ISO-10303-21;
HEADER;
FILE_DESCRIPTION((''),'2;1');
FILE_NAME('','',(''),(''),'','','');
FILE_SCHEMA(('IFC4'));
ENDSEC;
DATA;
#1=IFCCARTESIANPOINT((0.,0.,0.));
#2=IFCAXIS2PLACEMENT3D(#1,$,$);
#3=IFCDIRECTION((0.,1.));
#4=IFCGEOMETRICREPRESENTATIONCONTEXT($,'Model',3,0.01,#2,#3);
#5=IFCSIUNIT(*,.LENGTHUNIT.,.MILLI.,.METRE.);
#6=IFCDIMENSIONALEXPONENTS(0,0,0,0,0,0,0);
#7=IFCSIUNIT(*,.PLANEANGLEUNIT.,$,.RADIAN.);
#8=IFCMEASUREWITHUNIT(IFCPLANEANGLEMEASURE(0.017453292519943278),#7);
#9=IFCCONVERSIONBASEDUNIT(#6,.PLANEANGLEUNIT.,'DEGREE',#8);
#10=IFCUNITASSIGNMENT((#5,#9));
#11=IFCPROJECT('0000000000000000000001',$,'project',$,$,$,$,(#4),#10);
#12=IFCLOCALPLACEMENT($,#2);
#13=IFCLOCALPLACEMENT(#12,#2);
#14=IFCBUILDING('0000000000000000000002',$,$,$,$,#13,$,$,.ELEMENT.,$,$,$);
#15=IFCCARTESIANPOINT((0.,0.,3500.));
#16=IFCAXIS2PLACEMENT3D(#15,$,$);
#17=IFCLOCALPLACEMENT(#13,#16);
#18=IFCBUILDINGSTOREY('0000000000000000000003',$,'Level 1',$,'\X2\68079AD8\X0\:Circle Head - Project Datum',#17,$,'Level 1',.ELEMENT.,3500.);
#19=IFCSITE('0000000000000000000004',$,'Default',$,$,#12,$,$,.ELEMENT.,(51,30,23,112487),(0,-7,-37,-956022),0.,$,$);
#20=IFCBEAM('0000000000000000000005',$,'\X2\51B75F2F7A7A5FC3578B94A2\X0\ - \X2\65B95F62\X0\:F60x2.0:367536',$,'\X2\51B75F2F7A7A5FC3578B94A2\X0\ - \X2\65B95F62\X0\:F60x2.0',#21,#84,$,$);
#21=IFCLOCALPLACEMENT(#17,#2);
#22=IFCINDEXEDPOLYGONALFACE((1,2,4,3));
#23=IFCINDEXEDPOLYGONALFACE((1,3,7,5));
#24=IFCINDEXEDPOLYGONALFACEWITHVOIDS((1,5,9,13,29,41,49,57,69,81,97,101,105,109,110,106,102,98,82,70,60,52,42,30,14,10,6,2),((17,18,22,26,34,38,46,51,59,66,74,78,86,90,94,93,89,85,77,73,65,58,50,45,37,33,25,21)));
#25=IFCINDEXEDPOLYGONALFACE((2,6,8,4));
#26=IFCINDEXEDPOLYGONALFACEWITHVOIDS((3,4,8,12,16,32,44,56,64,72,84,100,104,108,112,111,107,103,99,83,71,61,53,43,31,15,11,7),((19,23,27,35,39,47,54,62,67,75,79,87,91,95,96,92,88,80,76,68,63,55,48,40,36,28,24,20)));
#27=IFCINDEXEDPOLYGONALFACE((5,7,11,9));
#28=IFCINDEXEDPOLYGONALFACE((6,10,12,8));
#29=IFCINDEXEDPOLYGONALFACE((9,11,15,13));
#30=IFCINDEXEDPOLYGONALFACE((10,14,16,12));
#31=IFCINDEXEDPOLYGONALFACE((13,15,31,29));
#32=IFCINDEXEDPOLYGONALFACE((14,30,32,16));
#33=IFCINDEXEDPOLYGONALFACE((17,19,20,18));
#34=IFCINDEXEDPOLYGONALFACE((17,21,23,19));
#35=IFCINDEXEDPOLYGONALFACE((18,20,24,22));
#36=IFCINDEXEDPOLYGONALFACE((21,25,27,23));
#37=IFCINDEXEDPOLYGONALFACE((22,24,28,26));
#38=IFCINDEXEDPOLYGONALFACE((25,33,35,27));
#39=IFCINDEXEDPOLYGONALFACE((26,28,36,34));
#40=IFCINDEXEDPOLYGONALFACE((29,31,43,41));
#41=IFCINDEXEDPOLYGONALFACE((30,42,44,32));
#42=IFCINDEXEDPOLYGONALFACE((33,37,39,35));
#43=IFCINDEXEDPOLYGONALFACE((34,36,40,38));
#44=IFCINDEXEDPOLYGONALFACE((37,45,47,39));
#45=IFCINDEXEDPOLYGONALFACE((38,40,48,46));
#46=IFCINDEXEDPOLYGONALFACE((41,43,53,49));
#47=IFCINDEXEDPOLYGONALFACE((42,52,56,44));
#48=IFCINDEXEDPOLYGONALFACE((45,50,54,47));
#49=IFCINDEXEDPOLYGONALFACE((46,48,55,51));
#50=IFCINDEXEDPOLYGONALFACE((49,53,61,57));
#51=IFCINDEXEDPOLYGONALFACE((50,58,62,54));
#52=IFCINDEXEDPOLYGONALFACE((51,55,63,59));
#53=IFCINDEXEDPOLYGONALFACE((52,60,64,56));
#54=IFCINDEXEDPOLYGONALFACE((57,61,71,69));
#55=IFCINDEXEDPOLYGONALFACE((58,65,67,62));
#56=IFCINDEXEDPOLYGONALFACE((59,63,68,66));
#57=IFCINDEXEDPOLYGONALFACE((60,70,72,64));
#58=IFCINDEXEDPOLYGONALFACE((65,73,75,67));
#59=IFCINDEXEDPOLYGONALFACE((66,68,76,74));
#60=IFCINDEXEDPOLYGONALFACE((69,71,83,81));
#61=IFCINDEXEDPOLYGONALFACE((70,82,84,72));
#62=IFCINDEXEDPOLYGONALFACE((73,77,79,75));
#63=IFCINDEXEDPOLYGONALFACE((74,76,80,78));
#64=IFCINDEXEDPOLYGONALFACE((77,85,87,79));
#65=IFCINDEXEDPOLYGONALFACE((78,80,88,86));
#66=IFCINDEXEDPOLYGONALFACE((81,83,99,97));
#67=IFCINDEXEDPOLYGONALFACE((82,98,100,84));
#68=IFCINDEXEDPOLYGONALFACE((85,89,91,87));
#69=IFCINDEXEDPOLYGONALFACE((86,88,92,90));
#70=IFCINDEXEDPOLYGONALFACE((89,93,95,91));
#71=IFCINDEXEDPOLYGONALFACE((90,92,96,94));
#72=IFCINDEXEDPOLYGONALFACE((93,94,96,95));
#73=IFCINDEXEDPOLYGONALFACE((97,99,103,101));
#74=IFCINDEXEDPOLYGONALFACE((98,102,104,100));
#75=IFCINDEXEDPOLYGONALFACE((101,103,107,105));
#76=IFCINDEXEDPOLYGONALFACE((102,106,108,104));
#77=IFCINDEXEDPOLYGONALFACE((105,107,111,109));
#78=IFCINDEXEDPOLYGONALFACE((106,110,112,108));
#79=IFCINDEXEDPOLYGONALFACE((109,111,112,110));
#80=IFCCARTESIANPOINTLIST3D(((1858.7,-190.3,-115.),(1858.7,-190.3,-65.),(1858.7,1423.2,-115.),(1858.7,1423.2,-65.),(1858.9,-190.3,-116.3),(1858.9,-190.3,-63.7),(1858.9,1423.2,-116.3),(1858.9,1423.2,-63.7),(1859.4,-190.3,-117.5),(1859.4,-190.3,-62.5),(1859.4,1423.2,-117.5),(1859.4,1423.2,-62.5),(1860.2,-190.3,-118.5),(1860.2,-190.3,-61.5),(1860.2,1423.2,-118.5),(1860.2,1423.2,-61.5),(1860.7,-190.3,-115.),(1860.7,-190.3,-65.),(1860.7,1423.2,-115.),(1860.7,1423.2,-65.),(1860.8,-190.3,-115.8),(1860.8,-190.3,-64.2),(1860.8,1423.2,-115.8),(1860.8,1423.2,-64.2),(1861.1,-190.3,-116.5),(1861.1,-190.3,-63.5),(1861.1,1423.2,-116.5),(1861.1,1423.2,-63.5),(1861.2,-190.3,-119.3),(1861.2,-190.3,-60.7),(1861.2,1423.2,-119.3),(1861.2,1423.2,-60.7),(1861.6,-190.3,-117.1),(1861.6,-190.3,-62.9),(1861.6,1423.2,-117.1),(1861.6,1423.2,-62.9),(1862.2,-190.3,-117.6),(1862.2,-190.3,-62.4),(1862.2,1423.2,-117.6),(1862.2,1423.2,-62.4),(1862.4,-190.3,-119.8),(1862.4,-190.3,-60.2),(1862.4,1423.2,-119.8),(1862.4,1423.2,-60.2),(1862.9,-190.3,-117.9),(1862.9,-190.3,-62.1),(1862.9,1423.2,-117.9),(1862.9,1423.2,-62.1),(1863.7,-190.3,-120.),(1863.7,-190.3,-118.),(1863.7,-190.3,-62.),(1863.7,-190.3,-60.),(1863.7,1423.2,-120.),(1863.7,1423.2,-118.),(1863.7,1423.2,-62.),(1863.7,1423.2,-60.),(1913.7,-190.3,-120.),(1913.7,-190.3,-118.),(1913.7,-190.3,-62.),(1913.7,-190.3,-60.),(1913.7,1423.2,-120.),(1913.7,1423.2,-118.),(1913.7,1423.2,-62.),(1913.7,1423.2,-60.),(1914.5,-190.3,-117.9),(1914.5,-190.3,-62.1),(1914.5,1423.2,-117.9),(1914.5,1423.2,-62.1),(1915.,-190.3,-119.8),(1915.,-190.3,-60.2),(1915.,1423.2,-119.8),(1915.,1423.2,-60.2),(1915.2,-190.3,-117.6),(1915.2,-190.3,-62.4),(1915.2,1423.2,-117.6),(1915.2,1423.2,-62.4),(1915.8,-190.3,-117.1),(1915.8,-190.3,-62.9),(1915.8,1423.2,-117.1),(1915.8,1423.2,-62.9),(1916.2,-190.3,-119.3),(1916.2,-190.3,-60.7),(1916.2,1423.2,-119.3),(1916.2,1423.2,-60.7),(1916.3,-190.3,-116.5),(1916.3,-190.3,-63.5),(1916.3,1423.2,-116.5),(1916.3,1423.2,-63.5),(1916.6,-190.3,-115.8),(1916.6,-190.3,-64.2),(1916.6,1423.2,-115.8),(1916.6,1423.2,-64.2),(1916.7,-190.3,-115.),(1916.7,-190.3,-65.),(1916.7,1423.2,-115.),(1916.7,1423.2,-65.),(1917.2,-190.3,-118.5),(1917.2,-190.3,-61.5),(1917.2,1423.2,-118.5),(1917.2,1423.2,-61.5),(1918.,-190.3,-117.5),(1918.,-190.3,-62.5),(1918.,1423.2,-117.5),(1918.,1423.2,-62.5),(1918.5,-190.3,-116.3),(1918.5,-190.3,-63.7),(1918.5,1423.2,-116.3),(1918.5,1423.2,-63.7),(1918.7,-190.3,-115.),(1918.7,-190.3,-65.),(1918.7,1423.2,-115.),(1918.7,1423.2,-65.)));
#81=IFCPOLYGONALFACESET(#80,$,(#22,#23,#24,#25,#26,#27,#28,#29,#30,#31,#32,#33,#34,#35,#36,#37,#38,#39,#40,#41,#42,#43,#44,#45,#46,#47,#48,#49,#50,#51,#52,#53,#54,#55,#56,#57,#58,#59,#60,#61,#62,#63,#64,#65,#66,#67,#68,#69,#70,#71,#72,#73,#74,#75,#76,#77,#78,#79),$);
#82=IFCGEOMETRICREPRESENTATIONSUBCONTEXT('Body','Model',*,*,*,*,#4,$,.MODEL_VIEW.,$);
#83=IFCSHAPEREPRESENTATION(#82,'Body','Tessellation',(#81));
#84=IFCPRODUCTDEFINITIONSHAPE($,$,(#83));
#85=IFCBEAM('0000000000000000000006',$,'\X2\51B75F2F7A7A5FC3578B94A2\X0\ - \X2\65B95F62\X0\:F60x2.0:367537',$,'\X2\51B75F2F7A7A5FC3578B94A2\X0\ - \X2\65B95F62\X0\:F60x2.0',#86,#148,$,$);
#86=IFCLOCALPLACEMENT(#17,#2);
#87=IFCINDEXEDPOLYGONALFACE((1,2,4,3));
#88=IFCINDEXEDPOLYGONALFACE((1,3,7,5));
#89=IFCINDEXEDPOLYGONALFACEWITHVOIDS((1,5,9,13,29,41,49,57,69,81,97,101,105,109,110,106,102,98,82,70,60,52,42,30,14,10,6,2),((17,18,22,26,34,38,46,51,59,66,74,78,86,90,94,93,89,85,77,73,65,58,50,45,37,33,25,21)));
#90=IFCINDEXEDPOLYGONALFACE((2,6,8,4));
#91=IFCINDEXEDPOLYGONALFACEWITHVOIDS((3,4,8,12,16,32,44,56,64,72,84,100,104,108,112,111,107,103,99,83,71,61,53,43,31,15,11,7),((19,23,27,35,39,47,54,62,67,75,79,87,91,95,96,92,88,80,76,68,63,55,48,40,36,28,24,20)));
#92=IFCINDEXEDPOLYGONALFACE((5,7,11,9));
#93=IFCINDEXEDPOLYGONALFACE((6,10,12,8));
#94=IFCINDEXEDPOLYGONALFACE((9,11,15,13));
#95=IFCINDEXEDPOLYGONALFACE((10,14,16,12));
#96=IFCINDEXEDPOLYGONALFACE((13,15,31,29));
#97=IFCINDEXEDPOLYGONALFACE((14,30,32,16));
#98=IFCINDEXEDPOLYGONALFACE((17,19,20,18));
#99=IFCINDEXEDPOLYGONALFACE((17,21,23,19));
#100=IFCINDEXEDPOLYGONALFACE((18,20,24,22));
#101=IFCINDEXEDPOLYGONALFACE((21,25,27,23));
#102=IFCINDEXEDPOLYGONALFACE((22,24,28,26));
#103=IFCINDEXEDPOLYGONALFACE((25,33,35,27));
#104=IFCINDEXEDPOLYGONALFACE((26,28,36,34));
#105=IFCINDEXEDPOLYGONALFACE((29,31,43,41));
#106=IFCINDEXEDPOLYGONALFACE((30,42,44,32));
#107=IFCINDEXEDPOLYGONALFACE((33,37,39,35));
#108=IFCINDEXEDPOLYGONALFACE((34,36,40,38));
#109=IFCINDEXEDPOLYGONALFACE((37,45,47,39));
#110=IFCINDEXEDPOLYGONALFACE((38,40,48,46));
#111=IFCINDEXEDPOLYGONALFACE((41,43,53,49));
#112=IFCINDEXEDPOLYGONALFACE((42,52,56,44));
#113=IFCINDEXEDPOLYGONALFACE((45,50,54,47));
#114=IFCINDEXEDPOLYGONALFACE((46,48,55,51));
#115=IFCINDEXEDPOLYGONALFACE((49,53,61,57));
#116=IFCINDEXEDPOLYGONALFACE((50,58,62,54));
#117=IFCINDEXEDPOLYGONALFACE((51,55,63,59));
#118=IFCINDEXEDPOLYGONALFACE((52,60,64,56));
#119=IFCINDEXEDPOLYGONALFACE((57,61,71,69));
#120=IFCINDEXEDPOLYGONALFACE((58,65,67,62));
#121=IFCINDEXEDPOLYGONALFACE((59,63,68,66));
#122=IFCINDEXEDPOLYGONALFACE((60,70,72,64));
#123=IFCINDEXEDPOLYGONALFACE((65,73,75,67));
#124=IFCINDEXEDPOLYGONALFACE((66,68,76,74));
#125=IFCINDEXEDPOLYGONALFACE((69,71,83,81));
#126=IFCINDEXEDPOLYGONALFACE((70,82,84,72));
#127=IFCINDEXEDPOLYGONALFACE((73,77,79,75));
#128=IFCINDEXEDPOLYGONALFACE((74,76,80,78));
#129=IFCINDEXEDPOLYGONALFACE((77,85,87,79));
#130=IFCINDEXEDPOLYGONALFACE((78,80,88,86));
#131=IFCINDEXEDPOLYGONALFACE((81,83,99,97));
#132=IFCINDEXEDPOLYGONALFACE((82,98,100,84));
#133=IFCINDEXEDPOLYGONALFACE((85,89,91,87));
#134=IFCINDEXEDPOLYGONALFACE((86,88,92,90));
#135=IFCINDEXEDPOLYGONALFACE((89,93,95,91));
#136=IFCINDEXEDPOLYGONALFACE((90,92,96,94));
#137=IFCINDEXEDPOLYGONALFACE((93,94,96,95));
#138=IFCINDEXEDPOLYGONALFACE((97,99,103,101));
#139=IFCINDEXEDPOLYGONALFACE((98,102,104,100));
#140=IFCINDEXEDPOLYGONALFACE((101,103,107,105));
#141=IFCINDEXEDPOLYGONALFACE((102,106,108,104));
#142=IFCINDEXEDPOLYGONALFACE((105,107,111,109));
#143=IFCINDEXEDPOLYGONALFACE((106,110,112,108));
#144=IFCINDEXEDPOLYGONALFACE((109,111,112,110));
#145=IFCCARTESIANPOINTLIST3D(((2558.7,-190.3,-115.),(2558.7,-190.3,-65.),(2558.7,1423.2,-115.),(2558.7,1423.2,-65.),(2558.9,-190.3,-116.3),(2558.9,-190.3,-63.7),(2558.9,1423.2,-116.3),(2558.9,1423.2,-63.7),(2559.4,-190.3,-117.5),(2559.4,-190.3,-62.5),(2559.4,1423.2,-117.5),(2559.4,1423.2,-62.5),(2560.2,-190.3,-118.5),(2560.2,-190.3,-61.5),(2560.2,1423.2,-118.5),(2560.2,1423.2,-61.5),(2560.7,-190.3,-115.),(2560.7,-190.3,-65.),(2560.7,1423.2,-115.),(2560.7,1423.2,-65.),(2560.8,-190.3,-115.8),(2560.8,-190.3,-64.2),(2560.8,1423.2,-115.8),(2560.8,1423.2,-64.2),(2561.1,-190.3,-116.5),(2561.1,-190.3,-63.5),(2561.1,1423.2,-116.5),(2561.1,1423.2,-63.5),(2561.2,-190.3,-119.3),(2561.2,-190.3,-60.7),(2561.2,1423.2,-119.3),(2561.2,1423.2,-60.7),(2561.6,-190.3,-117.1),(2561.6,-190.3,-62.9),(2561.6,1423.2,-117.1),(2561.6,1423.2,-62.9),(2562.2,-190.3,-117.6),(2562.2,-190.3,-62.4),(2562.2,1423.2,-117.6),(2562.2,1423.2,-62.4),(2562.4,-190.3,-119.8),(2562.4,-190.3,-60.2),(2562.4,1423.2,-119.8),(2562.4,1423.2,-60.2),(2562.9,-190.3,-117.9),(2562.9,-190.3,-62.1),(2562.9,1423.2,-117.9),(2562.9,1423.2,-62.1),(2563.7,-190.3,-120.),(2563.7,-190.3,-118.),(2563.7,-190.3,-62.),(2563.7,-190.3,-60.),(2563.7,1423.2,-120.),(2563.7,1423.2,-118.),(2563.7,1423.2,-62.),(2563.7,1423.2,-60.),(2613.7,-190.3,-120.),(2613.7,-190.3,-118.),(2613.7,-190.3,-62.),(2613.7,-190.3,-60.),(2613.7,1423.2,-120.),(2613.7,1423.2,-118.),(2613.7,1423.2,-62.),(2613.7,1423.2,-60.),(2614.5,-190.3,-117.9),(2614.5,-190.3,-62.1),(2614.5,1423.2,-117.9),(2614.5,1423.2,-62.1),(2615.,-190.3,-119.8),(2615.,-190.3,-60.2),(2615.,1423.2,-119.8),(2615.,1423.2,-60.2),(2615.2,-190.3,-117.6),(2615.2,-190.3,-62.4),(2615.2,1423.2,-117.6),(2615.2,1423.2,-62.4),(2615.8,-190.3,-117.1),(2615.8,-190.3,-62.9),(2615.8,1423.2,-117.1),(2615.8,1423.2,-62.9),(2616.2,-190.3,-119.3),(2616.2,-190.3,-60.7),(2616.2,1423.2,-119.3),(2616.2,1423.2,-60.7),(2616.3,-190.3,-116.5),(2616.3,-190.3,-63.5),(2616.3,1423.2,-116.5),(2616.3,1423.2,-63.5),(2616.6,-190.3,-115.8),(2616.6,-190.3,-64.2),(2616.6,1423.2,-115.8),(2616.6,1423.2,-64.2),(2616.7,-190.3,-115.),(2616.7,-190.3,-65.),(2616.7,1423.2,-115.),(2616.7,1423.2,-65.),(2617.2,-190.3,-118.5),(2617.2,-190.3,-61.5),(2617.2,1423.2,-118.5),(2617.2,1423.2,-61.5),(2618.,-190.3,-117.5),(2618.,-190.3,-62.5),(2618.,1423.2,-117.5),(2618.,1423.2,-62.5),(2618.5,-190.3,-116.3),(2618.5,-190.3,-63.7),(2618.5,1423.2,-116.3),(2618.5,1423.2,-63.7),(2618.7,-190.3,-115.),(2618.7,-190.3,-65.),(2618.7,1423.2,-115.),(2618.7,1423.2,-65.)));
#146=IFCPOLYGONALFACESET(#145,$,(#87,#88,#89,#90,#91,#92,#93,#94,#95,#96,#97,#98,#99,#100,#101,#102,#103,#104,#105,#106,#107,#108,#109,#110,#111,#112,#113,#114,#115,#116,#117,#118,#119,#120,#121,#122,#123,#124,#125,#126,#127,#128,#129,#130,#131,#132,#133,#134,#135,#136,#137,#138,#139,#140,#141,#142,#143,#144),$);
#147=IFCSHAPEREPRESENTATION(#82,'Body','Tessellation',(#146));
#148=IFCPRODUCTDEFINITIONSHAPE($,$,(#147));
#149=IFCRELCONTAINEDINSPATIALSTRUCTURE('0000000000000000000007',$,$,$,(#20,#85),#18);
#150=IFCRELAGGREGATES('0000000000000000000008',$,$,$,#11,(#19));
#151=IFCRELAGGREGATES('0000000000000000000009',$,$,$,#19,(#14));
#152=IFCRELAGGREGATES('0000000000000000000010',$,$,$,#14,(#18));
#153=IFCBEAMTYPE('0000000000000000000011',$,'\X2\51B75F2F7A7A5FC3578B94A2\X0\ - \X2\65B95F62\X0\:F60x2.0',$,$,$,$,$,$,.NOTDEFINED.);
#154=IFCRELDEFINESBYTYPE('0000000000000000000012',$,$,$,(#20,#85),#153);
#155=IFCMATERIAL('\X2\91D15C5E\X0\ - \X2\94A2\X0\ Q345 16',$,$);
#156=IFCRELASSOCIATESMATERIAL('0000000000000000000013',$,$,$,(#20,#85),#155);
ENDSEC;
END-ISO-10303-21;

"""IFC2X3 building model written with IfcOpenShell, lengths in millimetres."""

from ifc_helpers import new_model, entity, si_unit, converted_unit, direction, frame, frame_2d, origin, place, context, subcontext, project, spatial, polyline, circle_curve, parameter, trimmed, segment, composite_curve, outline, extrude, material, type_object, element, save


model = new_model("IFC2X3")

# Units and contexts
model_context = context("Model", 3, precision=0.01, world=origin(), true_north=direction((0.0, 1.0)))
body_context = subcontext(model_context, "Body", "Model", "MODEL_VIEW")
ifc_project = project(units=[si_unit("LENGTHUNIT", "METRE", prefix="MILLI"), converted_unit("PLANEANGLEUNIT", "DEGREE", entity("IfcPlaneAngleMeasure", 0.017453292519943278), si_unit("PLANEANGLEUNIT", "RADIAN"), dimensions=[0, 0, 0, 0, 0, 0, 0])], contexts=[model_context])

# Site, building, storey
site_placement = place(None, origin())
site = spatial("IfcSite", under=ifc_project, at=site_placement, Name="Default", CompositionType="ELEMENT", RefLatitude=(51, 30, 23, 112487), RefLongitude=(0, -7, -37, -956022), RefElevation=0.0)
building_placement = place(site_placement, origin())
building = spatial("IfcBuilding", under=site, at=building_placement, CompositionType="ELEMENT")
storey_placement = place(building_placement, frame((0.0, 0.0, 3500.0)))
storey = spatial("IfcBuildingStorey", under=building, at=storey_placement, Name="Level 1", ObjectType="标高:Circle Head - Project Datum", LongName="Level 1", CompositionType="ELEMENT", Elevation=3500.0)

# Beams
ifc_material_1 = material(Name="金属 - 钢 Q345 16")
beam_type_1 = type_object("IfcBeamType", Name="冷弯空心型钢 - 方形:F60x2.0", PredefinedType="NOTDEFINED")
beam_1_placement = place(storey_placement, frame((1888.7, 1388.1, -60.0), z_axis=(0.0, 0.0, 1.0), x_axis=(0.0, -1.0, 0.0)))
element("IfcBeam", 1, at=beam_1_placement, inside=storey, type_object=beam_type_1, material=ifc_material_1, Name="冷弯空心型钢 - 方形:F60x2.0:367536", ObjectType="冷弯空心型钢 - 方形:F60x2.0", context=body_context, shape_type="SweptSolid", body=[
    extrude(outline(composite_curve([segment(trimmed(circle_curve(frame_2d((-25.0, 25.0), x_axis=(1.0, 0.0)), 5.0), [parameter(90.0)], [parameter(180.0)], True, "PARAMETER"), True, "CONTINUOUS"), segment(polyline([(-30.0, 25.0), (-30.0, -25.0)]), True, "CONTINUOUS"), segment(trimmed(circle_curve(frame_2d((-25.0, -25.0), x_axis=(1.0, 0.0)), 5.0), [parameter(180.0)], [parameter(270.0)], True, "PARAMETER"), True, "CONTINUOUS"), segment(polyline([(-25.0, -30.0), (25.0, -30.0)]), True, "CONTINUOUS"), segment(trimmed(circle_curve(frame_2d((25.0, -25.0), x_axis=(1.0, 0.0)), 5.0), [parameter(270.0)], [parameter(0.0)], True, "PARAMETER"), True, "CONTINUOUS"), segment(polyline([(30.0, -25.0), (30.0, 25.0)]), True, "CONTINUOUS"), segment(trimmed(circle_curve(frame_2d((25.0, 25.0), x_axis=(1.0, 0.0)), 5.0), [parameter(0.0)], [parameter(90.0)], True, "PARAMETER"), True, "CONTINUOUS"), segment(polyline([(25.0, 30.0), (-25.0, 30.0)]), True, "CONTINUOUS")], self_intersect=False), holes=[composite_curve([segment(polyline([(-25.0, 28.0), (25.0, 28.0)]), True, "CONTINUOUS"), segment(trimmed(circle_curve(frame_2d((25.0, 25.0), x_axis=(1.0, 0.0)), 3.0), [parameter(0.0)], [parameter(90.0)], True, "PARAMETER"), False, "CONTINUOUS"), segment(polyline([(28.0, 25.0), (28.0, -25.0)]), True, "CONTINUOUS"), segment(trimmed(circle_curve(frame_2d((25.0, -25.0), x_axis=(1.0, 0.0)), 3.0), [parameter(270.0)], [parameter(360.0)], True, "PARAMETER"), False, "CONTINUOUS"), segment(polyline([(25.0, -28.0), (-25.0, -28.0)]), True, "CONTINUOUS"), segment(trimmed(circle_curve(frame_2d((-25.0, -25.0), x_axis=(1.0, 0.0)), 3.0), [parameter(180.0)], [parameter(270.0)], True, "PARAMETER"), False, "CONTINUOUS"), segment(polyline([(-28.0, -25.0), (-28.0, 25.0)]), True, "CONTINUOUS"), segment(trimmed(circle_curve(frame_2d((-25.0, 25.0), x_axis=(1.0, 0.0)), 3.0), [parameter(90.0)], [parameter(180.0)], True, "PARAMETER"), False, "CONTINUOUS")], self_intersect=False)]), frame((-35.1, 0.0, -30.0), z_axis=(1.0, 0.0, 0.0), x_axis=(0.0, 1.0, 0.0)), (0.0, 0.0, 1.0), 1613.5),
])
beam_2_placement = place(storey_placement, frame((2588.7, 1388.1, -60.0), z_axis=(0.0, 0.0, 1.0), x_axis=(0.0, -1.0, 0.0)))
element("IfcBeam", 2, at=beam_2_placement, inside=storey, type_object=beam_type_1, material=ifc_material_1, Name="冷弯空心型钢 - 方形:F60x2.0:367537", ObjectType="冷弯空心型钢 - 方形:F60x2.0", context=body_context, shape_type="SweptSolid", body=[
    extrude(outline(composite_curve([segment(trimmed(circle_curve(frame_2d((-25.0, 25.0), x_axis=(1.0, 0.0)), 5.0), [parameter(90.0)], [parameter(180.0)], True, "PARAMETER"), True, "CONTINUOUS"), segment(polyline([(-30.0, 25.0), (-30.0, -25.0)]), True, "CONTINUOUS"), segment(trimmed(circle_curve(frame_2d((-25.0, -25.0), x_axis=(1.0, 0.0)), 5.0), [parameter(180.0)], [parameter(270.0)], True, "PARAMETER"), True, "CONTINUOUS"), segment(polyline([(-25.0, -30.0), (25.0, -30.0)]), True, "CONTINUOUS"), segment(trimmed(circle_curve(frame_2d((25.0, -25.0), x_axis=(1.0, 0.0)), 5.0), [parameter(270.0)], [parameter(0.0)], True, "PARAMETER"), True, "CONTINUOUS"), segment(polyline([(30.0, -25.0), (30.0, 25.0)]), True, "CONTINUOUS"), segment(trimmed(circle_curve(frame_2d((25.0, 25.0), x_axis=(1.0, 0.0)), 5.0), [parameter(0.0)], [parameter(90.0)], True, "PARAMETER"), True, "CONTINUOUS"), segment(polyline([(25.0, 30.0), (-25.0, 30.0)]), True, "CONTINUOUS")], self_intersect=False), holes=[composite_curve([segment(polyline([(-25.0, 28.0), (25.0, 28.0)]), True, "CONTINUOUS"), segment(trimmed(circle_curve(frame_2d((25.0, 25.0), x_axis=(1.0, 0.0)), 3.0), [parameter(0.0)], [parameter(90.0)], True, "PARAMETER"), False, "CONTINUOUS"), segment(polyline([(28.0, 25.0), (28.0, -25.0)]), True, "CONTINUOUS"), segment(trimmed(circle_curve(frame_2d((25.0, -25.0), x_axis=(1.0, 0.0)), 3.0), [parameter(270.0)], [parameter(360.0)], True, "PARAMETER"), False, "CONTINUOUS"), segment(polyline([(25.0, -28.0), (-25.0, -28.0)]), True, "CONTINUOUS"), segment(trimmed(circle_curve(frame_2d((-25.0, -25.0), x_axis=(1.0, 0.0)), 3.0), [parameter(180.0)], [parameter(270.0)], True, "PARAMETER"), False, "CONTINUOUS"), segment(polyline([(-28.0, -25.0), (-28.0, 25.0)]), True, "CONTINUOUS"), segment(trimmed(circle_curve(frame_2d((-25.0, 25.0), x_axis=(1.0, 0.0)), 3.0), [parameter(90.0)], [parameter(180.0)], True, "PARAMETER"), False, "CONTINUOUS")], self_intersect=False)]), frame((-35.1, 0.0, -30.0), z_axis=(1.0, 0.0, 0.0), x_axis=(0.0, 1.0, 0.0)), (0.0, 0.0, 1.0), 1613.5),
])

save(model, "model.ifc")
